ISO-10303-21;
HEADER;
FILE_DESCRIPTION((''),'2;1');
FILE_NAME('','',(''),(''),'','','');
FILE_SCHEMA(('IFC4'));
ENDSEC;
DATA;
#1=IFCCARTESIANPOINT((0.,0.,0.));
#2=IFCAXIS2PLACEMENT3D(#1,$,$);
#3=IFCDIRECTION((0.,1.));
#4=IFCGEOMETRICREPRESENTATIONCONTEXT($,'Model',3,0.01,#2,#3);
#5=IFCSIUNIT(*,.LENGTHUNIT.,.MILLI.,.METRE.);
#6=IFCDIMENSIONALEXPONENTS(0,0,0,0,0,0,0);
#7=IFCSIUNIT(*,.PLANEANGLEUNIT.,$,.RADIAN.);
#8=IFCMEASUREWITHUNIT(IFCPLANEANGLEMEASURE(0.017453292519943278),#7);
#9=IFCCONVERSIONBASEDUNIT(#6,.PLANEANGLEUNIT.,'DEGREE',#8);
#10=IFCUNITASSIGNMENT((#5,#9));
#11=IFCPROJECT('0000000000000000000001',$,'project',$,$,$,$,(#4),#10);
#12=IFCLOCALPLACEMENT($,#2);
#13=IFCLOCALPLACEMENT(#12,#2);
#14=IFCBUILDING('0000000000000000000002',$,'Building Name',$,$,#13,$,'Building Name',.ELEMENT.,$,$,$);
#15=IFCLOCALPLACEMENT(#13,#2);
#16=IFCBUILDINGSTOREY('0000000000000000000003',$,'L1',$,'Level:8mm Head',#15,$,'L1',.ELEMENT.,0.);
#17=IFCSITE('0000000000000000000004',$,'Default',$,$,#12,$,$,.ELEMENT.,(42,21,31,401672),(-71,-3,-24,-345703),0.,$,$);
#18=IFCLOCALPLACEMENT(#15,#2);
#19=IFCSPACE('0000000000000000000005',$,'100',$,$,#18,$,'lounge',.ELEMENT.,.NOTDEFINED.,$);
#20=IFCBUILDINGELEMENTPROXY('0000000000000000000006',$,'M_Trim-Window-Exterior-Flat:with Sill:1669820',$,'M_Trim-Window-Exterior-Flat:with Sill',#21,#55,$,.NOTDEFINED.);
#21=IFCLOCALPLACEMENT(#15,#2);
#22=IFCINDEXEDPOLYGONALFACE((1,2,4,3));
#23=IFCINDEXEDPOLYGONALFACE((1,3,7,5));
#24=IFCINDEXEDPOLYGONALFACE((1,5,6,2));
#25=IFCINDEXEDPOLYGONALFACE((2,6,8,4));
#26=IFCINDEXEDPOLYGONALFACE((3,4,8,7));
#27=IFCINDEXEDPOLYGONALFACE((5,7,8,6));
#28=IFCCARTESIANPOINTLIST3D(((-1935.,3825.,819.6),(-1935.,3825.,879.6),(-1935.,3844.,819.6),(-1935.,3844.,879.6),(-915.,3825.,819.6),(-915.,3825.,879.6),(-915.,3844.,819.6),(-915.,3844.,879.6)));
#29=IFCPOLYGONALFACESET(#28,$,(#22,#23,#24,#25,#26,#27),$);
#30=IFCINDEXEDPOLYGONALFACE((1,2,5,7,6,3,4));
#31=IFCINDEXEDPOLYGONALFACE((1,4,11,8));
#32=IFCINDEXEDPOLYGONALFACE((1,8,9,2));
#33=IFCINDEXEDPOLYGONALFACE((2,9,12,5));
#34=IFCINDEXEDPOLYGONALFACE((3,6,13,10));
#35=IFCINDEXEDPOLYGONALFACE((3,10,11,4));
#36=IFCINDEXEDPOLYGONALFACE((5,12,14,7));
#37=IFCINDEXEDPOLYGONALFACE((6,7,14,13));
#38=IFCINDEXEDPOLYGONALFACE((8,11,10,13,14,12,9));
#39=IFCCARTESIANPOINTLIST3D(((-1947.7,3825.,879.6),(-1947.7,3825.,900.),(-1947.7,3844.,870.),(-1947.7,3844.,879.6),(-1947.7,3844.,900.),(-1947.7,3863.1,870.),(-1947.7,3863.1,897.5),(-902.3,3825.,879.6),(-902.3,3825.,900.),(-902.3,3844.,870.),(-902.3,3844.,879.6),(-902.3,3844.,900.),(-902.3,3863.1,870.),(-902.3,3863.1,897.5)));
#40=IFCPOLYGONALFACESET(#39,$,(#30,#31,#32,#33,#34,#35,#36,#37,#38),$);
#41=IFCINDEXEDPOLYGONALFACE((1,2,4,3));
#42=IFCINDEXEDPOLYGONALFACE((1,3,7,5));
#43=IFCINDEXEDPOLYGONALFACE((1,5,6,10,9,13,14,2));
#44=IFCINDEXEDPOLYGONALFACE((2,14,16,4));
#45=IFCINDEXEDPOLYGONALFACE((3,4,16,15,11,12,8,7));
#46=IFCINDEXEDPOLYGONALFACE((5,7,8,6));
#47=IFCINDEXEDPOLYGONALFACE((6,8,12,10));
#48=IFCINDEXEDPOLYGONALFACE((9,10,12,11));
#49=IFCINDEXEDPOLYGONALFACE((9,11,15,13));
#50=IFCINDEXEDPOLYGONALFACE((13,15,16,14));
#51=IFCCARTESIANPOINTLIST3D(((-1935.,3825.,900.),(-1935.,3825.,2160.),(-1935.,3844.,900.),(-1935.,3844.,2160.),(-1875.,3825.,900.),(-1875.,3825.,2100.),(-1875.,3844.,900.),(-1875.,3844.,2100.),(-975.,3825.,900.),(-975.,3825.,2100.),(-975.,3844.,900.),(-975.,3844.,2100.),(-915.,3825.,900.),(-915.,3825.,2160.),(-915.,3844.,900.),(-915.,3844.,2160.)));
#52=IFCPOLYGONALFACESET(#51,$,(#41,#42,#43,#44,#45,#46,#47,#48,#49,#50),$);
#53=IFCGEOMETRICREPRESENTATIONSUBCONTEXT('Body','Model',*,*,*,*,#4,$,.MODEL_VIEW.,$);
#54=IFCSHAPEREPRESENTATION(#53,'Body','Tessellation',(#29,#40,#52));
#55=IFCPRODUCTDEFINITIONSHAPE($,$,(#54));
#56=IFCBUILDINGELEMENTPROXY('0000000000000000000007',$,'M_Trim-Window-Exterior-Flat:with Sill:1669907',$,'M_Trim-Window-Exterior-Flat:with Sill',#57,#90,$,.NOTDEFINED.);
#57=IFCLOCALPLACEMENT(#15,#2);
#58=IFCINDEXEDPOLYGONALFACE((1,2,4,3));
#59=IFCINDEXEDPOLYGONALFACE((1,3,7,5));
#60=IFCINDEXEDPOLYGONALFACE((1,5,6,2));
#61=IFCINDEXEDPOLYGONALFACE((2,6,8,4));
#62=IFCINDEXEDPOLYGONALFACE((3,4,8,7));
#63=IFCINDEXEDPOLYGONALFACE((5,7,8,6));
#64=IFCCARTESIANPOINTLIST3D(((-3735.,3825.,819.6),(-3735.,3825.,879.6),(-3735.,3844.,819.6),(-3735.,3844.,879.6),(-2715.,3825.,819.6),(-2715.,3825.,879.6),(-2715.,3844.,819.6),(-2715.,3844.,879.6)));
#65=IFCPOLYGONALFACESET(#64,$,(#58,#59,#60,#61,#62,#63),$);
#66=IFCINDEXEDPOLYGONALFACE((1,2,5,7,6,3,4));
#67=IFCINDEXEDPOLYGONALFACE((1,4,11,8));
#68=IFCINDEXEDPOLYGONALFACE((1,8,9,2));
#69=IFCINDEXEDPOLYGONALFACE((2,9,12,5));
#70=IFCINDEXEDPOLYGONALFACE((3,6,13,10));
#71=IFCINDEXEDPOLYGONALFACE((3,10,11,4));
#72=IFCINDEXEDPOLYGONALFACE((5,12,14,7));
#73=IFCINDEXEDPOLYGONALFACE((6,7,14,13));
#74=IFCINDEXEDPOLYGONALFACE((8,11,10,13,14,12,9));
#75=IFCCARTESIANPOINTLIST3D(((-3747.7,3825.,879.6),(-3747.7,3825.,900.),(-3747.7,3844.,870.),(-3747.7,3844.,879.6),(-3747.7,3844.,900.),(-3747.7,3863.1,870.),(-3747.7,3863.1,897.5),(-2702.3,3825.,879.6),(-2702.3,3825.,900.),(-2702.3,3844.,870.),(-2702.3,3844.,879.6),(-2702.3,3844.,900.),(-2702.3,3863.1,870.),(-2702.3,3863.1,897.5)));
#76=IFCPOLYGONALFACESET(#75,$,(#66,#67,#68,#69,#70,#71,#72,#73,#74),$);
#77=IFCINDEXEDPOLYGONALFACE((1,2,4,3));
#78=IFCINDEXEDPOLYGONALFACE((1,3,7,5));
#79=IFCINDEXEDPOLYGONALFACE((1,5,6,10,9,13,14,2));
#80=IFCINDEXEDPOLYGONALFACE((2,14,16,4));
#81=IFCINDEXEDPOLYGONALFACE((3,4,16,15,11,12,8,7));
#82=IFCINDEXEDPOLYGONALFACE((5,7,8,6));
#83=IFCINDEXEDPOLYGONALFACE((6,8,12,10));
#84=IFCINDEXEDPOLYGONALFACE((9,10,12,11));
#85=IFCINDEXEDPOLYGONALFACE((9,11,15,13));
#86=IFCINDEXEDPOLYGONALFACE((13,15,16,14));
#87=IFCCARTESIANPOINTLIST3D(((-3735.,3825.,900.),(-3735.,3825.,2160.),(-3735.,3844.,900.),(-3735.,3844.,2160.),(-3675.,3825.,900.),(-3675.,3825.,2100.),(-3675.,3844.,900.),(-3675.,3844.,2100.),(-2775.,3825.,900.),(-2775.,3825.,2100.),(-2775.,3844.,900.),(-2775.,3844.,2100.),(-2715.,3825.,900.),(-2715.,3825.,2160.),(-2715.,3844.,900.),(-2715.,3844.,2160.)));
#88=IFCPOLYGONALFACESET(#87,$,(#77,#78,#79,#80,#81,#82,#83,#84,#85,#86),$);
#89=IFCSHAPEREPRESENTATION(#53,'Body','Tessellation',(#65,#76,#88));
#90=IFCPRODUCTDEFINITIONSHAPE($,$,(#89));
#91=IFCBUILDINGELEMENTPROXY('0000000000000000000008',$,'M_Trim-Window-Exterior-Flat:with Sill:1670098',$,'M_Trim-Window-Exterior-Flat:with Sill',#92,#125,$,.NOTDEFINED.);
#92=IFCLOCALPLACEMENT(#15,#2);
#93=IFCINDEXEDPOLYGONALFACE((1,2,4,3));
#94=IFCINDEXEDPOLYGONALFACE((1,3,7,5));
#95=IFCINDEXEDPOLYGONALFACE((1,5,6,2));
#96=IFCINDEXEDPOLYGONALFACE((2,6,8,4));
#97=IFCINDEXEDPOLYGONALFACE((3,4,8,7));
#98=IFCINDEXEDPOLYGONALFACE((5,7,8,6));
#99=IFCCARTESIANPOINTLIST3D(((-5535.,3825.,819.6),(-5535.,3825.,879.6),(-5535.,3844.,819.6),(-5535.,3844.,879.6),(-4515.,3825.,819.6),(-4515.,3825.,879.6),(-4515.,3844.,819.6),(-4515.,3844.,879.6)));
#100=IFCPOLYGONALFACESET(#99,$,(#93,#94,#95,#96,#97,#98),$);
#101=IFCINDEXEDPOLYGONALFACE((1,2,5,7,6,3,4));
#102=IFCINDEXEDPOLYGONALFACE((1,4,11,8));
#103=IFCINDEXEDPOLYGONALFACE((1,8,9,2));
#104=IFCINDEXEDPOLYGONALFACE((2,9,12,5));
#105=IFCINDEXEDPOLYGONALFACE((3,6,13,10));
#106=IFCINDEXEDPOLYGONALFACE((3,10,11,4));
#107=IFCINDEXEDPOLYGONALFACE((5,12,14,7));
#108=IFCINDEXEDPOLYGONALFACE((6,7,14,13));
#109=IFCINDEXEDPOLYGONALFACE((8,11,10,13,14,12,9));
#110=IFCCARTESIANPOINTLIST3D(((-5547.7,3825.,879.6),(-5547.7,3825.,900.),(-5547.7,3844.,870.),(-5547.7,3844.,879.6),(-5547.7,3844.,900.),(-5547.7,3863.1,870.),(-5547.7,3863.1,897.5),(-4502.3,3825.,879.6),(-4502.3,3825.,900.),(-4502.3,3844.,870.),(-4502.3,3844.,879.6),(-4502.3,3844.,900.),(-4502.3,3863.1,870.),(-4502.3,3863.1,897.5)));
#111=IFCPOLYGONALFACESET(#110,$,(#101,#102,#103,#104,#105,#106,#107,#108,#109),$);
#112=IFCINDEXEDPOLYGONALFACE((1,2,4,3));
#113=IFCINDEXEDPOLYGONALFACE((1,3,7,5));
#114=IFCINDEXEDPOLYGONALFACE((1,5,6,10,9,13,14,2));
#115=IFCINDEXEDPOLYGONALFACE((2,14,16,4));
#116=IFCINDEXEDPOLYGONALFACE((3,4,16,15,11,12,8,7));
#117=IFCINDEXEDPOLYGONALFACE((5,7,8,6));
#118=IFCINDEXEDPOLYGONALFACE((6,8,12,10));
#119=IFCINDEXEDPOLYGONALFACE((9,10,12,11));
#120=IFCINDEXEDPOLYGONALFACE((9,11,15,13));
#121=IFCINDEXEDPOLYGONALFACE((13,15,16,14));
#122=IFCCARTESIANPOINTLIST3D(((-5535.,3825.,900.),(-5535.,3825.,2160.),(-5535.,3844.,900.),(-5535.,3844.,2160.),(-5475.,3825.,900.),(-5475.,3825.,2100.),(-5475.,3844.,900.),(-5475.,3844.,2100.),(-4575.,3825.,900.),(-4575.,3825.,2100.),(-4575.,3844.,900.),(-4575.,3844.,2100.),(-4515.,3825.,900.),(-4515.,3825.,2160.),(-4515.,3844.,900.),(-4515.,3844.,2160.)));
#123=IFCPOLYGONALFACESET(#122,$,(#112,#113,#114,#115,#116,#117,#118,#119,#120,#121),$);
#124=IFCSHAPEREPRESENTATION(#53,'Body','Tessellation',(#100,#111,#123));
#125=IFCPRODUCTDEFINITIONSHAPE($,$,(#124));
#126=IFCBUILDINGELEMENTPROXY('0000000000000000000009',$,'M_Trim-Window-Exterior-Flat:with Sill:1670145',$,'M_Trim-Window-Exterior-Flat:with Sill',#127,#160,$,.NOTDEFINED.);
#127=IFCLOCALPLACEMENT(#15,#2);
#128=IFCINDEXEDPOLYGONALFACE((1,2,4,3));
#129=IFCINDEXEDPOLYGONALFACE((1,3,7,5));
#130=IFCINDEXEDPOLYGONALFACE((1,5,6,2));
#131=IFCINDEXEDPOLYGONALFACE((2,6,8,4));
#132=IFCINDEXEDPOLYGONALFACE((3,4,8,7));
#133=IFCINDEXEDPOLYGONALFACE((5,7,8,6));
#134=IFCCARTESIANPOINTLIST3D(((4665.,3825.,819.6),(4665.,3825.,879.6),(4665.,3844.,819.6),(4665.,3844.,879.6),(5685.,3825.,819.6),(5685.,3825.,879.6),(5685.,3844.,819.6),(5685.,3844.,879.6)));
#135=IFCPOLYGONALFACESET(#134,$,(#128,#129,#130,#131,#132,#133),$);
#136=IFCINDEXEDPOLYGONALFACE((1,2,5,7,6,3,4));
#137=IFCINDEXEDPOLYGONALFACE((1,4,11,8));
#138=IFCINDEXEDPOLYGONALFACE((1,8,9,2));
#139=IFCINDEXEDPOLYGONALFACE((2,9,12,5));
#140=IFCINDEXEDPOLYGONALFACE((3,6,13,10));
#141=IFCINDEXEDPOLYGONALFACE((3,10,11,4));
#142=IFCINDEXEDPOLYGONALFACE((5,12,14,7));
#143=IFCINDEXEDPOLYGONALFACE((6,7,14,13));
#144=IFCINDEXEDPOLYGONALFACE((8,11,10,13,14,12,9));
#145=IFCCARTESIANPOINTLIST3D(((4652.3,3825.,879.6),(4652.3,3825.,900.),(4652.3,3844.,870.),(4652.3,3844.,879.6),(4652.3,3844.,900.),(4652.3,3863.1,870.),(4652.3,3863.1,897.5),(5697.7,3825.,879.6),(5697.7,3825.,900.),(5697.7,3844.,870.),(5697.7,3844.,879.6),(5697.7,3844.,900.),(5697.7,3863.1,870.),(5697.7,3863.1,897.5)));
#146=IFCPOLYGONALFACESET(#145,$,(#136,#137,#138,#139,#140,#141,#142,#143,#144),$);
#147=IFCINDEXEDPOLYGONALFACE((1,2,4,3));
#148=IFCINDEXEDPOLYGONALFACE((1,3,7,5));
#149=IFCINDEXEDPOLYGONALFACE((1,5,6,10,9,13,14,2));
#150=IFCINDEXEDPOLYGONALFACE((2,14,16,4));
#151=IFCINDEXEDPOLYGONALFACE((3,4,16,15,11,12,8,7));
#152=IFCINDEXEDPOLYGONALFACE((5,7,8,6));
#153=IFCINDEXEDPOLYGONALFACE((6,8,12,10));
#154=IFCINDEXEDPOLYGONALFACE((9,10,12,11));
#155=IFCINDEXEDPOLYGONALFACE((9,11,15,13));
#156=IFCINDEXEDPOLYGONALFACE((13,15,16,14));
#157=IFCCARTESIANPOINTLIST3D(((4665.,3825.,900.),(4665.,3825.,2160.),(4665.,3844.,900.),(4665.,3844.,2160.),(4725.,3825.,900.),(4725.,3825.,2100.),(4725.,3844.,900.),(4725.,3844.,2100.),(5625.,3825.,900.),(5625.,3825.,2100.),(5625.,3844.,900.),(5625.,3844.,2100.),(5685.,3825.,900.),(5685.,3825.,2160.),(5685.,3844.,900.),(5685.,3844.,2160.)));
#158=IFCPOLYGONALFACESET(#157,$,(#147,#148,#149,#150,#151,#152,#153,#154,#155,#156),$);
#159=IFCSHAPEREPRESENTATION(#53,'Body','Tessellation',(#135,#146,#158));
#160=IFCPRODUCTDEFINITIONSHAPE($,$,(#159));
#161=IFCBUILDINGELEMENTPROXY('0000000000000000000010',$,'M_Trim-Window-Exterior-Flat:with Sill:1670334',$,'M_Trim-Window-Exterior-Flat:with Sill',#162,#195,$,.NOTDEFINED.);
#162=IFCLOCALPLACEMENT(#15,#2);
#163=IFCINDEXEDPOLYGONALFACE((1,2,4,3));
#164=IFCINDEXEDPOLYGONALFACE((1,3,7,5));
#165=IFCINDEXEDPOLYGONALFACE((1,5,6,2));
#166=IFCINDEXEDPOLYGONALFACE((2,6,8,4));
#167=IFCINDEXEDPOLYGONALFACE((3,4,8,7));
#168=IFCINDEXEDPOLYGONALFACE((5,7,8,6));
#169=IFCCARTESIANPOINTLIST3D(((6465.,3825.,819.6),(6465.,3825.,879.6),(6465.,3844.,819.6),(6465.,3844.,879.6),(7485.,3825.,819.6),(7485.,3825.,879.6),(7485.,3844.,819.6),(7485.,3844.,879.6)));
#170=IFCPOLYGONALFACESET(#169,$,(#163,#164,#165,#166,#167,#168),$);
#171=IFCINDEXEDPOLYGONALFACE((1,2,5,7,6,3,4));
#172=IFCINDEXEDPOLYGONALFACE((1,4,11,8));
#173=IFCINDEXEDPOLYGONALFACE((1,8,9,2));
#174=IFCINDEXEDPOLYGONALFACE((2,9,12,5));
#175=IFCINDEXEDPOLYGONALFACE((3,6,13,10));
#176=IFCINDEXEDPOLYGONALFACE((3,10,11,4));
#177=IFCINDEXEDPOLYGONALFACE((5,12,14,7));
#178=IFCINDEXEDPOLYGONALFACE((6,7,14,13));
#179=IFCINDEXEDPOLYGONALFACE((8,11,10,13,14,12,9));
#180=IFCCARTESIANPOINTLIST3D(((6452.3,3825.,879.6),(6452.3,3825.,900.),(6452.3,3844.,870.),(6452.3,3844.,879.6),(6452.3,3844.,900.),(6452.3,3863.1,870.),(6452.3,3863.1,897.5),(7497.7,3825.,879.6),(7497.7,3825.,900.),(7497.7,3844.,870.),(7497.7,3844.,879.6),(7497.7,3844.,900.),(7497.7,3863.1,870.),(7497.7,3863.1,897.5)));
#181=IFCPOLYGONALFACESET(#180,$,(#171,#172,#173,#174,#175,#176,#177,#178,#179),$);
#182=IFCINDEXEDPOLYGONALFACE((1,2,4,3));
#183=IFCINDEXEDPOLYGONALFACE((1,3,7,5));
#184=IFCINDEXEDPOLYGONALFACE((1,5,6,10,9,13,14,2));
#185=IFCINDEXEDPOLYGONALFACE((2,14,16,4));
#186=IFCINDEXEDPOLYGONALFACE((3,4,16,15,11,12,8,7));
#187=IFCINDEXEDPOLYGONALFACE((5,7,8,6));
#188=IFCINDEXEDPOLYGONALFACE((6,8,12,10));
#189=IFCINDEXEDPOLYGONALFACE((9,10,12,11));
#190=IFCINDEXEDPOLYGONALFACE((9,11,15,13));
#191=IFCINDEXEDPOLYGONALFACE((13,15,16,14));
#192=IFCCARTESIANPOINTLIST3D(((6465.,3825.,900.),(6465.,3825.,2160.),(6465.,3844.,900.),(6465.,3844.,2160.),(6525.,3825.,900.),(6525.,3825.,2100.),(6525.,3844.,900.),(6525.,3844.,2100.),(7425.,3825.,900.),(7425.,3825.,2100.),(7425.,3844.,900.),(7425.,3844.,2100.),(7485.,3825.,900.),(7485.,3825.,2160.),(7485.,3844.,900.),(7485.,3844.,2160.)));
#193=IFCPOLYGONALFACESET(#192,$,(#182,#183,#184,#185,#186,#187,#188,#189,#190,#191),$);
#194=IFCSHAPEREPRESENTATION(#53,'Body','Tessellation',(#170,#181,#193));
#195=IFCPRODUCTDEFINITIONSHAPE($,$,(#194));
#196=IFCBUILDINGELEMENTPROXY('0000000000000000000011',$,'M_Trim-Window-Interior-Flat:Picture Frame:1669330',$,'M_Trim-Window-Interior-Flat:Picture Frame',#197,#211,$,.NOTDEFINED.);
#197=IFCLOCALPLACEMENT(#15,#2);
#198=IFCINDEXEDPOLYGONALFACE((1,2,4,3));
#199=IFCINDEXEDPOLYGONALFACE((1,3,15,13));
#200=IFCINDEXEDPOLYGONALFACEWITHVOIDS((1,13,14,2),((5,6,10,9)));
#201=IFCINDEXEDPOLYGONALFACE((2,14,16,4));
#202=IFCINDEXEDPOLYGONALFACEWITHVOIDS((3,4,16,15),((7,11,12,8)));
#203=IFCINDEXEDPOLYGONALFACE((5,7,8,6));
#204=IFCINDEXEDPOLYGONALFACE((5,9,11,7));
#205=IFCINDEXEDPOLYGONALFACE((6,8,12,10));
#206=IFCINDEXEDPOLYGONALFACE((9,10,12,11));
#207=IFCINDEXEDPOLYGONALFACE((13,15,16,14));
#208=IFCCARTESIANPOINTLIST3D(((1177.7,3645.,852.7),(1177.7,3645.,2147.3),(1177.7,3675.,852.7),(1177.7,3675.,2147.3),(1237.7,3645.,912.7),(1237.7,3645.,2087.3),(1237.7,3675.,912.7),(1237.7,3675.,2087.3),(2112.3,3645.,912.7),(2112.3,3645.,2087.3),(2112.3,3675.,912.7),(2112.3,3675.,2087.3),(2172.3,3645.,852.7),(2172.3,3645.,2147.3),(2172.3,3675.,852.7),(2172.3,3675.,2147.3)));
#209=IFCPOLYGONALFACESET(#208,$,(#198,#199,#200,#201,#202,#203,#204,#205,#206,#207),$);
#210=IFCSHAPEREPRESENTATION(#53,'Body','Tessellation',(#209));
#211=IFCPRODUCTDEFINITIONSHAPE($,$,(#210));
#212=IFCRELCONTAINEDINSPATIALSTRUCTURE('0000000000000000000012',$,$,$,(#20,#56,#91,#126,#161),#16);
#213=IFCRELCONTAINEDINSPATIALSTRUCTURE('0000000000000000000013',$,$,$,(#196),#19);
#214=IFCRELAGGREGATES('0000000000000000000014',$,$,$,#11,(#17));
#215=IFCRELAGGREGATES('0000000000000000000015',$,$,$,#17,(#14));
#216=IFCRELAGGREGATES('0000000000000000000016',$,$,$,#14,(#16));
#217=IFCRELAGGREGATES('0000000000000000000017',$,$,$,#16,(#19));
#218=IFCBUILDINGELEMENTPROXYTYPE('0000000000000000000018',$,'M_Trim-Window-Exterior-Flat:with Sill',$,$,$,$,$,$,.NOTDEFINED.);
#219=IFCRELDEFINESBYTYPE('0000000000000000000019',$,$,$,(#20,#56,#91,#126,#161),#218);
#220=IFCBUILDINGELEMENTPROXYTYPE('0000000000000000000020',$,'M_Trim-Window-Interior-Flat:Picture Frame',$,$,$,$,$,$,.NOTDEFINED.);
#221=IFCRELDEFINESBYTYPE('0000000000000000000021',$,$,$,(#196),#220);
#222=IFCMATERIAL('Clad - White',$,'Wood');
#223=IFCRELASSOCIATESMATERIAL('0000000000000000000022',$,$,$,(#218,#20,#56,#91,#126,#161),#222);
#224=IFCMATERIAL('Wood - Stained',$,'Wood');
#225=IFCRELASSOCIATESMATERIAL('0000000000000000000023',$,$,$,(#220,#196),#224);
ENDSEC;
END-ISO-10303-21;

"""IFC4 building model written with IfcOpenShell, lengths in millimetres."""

from ifc_helpers import new_model, entity, si_unit, converted_unit, direction, frame, frame_2d, origin, place, context, subcontext, project, spatial, polyline, rectangle, outline, extrude, source, transform, mapped, material, type_object, type_shapes, element, save


model = new_model("IFC4")

# Units and contexts
model_context = context("Model", 3, precision=0.01, world=origin(), true_north=direction((0.0, 1.0)))
body_context = subcontext(model_context, "Body", "Model", "MODEL_VIEW")
ifc_project = project(units=[si_unit("LENGTHUNIT", "METRE", prefix="MILLI"), converted_unit("PLANEANGLEUNIT", "DEGREE", entity("IfcPlaneAngleMeasure", 0.017453292519943278), si_unit("PLANEANGLEUNIT", "RADIAN"), dimensions=[0, 0, 0, 0, 0, 0, 0])], contexts=[model_context])

# Site, building, storey
site_placement = place(None, origin())
site = spatial("IfcSite", under=ifc_project, at=site_placement, Name="Default", CompositionType="ELEMENT", RefLatitude=(42, 21, 31, 401672), RefLongitude=(-71, -3, -24, -345703), RefElevation=0.0)
building_placement = place(site_placement, origin())
building = spatial("IfcBuilding", under=site, at=building_placement, Name="Building Name", LongName="Building Name", CompositionType="ELEMENT")
storey_placement = place(building_placement, origin())
storey = spatial("IfcBuildingStorey", under=building, at=storey_placement, Name="L1", ObjectType="Level:8mm Head", LongName="L1", CompositionType="ELEMENT", Elevation=0.0)

# Building element proxies
ifc_material_1 = material(Name="Clad - White", Category="Wood")
ifc_material_2 = material(Name="Wood - Stained", Category="Wood")
building_element_proxy_type_1 = type_object("IfcBuildingElementProxyType", Name="M_Trim-Window-Exterior-Flat:with Sill", PredefinedType="NOTDEFINED", material=ifc_material_1)
shared_shape_1 = source(origin(), body_context, "Body", "SweptSolid", [
    extrude(rectangle(XDim=1020.0, YDim=60.0, at=frame_2d((0.0, 0.0), x_axis=(1.0, 0.0))), frame((0.0, -1250.4, 0.0), z_axis=(0.0, 0.0, 1.0), x_axis=(-1.0, 0.0, 0.0)), (0.0, 0.0, 1.0), 19.0),
    extrude(outline(polyline([(-19.0, -15.2), (0.0, -15.2), (0.0, -5.7), (19.0, -5.7), (19.0, 14.8), (0.0, 14.8), (-19.0, 12.3), (-19.0, -15.2)])), frame((-522.7, -1214.8, 19.0), z_axis=(1.0, 0.0, 0.0), x_axis=(0.0, 0.0, -1.0)), (0.0, 0.0, 1.0), 1045.4),
    extrude(outline(polyline([(-645.0, -510.0), (615.0, -510.0), (615.0, -450.0), (-585.0, -450.0), (-585.0, 450.0), (615.0, 450.0), (615.0, 510.0), (-645.0, 510.0), (-645.0, -510.0)])), frame((0.0, -585.0, 0.0), z_axis=(0.0, 0.0, 1.0), x_axis=(0.0, -1.0, 0.0)), (0.0, 0.0, 1.0), 19.0),
])
type_shapes(building_element_proxy_type_1, [shared_shape_1])
for number, where, z_axis, x_axis, name in (
    (1, (-1425.0, 3825.0, 2100.0), (0.0, 1.0, 0.0), (-1.0, 0.0, 0.0), "M_Trim-Window-Exterior-Flat:with Sill:1669820"),
    (2, (-3225.0, 3825.0, 2100.0), (0.0, 1.0, 0.0), (-1.0, 0.0, 0.0), "M_Trim-Window-Exterior-Flat:with Sill:1669907"),
    (3, (-5025.0, 3825.0, 2100.0), (0.0, 1.0, 0.0), (-1.0, 0.0, 0.0), "M_Trim-Window-Exterior-Flat:with Sill:1670098"),
    (4, (5175.0, 3825.0, 2100.0), (0.0, 1.0, 0.0), (-1.0, 0.0, 0.0), "M_Trim-Window-Exterior-Flat:with Sill:1670145"),
    (5, (6975.0, 3825.0, 2100.0), (0.0, 1.0, 0.0), (-1.0, 0.0, 0.0), "M_Trim-Window-Exterior-Flat:with Sill:1670334"),
):
    element("IfcBuildingElementProxy", number, at=place(storey_placement, frame(where, z_axis=z_axis, x_axis=x_axis)), inside=storey, type_object=building_element_proxy_type_1, material=ifc_material_1, Name=name, ObjectType="M_Trim-Window-Exterior-Flat:with Sill", PredefinedType="NOTDEFINED", context=body_context, shape_type="MappedRepresentation", body=[
        mapped(shared_shape_1, transform((0.0, 0.0, 0.0), scale=1.0)),
    ])

# Shared definitions
space_placement = place(storey_placement, origin())
space = spatial("IfcSpace", under=storey, at=space_placement, Name="100", LongName="lounge", CompositionType="ELEMENT", PredefinedType="NOTDEFINED")

# Building element proxy
building_element_proxy_type_2 = type_object("IfcBuildingElementProxyType", Name="M_Trim-Window-Interior-Flat:Picture Frame", PredefinedType="NOTDEFINED", material=ifc_material_2)
shared_shape_2 = source(origin(), body_context, "Body", "SweptSolid", [
    extrude(outline(polyline([(-497.3, -647.3), (497.3, -647.3), (497.3, 647.3), (-497.3, 647.3), (-497.3, -647.3)]), holes=[polyline([(-437.3, -587.3), (-437.3, 587.3), (437.3, 587.3), (437.3, -587.3), (-437.3, -587.3)])]), frame((0.0, -600.0, 0.0), z_axis=(0.0, 0.0, 1.0), x_axis=(-1.0, 0.0, 0.0)), (0.0, 0.0, 1.0), 30.0),
])
type_shapes(building_element_proxy_type_2, [shared_shape_2])
proxy_1_placement = place(space_placement, frame((1675.0, 3675.0, 2100.0), z_axis=(0.0, -1.0, 0.0), x_axis=(1.0, 0.0, 0.0)))
element("IfcBuildingElementProxy", 6, at=proxy_1_placement, inside=space, type_object=building_element_proxy_type_2, material=ifc_material_2, Name="M_Trim-Window-Interior-Flat:Picture Frame:1669330", ObjectType="M_Trim-Window-Interior-Flat:Picture Frame", PredefinedType="NOTDEFINED", context=body_context, shape_type="MappedRepresentation", body=[
    mapped(shared_shape_2, transform((0.0, 0.0, 0.0), scale=1.0)),
])

save(model, "model.ifc")
